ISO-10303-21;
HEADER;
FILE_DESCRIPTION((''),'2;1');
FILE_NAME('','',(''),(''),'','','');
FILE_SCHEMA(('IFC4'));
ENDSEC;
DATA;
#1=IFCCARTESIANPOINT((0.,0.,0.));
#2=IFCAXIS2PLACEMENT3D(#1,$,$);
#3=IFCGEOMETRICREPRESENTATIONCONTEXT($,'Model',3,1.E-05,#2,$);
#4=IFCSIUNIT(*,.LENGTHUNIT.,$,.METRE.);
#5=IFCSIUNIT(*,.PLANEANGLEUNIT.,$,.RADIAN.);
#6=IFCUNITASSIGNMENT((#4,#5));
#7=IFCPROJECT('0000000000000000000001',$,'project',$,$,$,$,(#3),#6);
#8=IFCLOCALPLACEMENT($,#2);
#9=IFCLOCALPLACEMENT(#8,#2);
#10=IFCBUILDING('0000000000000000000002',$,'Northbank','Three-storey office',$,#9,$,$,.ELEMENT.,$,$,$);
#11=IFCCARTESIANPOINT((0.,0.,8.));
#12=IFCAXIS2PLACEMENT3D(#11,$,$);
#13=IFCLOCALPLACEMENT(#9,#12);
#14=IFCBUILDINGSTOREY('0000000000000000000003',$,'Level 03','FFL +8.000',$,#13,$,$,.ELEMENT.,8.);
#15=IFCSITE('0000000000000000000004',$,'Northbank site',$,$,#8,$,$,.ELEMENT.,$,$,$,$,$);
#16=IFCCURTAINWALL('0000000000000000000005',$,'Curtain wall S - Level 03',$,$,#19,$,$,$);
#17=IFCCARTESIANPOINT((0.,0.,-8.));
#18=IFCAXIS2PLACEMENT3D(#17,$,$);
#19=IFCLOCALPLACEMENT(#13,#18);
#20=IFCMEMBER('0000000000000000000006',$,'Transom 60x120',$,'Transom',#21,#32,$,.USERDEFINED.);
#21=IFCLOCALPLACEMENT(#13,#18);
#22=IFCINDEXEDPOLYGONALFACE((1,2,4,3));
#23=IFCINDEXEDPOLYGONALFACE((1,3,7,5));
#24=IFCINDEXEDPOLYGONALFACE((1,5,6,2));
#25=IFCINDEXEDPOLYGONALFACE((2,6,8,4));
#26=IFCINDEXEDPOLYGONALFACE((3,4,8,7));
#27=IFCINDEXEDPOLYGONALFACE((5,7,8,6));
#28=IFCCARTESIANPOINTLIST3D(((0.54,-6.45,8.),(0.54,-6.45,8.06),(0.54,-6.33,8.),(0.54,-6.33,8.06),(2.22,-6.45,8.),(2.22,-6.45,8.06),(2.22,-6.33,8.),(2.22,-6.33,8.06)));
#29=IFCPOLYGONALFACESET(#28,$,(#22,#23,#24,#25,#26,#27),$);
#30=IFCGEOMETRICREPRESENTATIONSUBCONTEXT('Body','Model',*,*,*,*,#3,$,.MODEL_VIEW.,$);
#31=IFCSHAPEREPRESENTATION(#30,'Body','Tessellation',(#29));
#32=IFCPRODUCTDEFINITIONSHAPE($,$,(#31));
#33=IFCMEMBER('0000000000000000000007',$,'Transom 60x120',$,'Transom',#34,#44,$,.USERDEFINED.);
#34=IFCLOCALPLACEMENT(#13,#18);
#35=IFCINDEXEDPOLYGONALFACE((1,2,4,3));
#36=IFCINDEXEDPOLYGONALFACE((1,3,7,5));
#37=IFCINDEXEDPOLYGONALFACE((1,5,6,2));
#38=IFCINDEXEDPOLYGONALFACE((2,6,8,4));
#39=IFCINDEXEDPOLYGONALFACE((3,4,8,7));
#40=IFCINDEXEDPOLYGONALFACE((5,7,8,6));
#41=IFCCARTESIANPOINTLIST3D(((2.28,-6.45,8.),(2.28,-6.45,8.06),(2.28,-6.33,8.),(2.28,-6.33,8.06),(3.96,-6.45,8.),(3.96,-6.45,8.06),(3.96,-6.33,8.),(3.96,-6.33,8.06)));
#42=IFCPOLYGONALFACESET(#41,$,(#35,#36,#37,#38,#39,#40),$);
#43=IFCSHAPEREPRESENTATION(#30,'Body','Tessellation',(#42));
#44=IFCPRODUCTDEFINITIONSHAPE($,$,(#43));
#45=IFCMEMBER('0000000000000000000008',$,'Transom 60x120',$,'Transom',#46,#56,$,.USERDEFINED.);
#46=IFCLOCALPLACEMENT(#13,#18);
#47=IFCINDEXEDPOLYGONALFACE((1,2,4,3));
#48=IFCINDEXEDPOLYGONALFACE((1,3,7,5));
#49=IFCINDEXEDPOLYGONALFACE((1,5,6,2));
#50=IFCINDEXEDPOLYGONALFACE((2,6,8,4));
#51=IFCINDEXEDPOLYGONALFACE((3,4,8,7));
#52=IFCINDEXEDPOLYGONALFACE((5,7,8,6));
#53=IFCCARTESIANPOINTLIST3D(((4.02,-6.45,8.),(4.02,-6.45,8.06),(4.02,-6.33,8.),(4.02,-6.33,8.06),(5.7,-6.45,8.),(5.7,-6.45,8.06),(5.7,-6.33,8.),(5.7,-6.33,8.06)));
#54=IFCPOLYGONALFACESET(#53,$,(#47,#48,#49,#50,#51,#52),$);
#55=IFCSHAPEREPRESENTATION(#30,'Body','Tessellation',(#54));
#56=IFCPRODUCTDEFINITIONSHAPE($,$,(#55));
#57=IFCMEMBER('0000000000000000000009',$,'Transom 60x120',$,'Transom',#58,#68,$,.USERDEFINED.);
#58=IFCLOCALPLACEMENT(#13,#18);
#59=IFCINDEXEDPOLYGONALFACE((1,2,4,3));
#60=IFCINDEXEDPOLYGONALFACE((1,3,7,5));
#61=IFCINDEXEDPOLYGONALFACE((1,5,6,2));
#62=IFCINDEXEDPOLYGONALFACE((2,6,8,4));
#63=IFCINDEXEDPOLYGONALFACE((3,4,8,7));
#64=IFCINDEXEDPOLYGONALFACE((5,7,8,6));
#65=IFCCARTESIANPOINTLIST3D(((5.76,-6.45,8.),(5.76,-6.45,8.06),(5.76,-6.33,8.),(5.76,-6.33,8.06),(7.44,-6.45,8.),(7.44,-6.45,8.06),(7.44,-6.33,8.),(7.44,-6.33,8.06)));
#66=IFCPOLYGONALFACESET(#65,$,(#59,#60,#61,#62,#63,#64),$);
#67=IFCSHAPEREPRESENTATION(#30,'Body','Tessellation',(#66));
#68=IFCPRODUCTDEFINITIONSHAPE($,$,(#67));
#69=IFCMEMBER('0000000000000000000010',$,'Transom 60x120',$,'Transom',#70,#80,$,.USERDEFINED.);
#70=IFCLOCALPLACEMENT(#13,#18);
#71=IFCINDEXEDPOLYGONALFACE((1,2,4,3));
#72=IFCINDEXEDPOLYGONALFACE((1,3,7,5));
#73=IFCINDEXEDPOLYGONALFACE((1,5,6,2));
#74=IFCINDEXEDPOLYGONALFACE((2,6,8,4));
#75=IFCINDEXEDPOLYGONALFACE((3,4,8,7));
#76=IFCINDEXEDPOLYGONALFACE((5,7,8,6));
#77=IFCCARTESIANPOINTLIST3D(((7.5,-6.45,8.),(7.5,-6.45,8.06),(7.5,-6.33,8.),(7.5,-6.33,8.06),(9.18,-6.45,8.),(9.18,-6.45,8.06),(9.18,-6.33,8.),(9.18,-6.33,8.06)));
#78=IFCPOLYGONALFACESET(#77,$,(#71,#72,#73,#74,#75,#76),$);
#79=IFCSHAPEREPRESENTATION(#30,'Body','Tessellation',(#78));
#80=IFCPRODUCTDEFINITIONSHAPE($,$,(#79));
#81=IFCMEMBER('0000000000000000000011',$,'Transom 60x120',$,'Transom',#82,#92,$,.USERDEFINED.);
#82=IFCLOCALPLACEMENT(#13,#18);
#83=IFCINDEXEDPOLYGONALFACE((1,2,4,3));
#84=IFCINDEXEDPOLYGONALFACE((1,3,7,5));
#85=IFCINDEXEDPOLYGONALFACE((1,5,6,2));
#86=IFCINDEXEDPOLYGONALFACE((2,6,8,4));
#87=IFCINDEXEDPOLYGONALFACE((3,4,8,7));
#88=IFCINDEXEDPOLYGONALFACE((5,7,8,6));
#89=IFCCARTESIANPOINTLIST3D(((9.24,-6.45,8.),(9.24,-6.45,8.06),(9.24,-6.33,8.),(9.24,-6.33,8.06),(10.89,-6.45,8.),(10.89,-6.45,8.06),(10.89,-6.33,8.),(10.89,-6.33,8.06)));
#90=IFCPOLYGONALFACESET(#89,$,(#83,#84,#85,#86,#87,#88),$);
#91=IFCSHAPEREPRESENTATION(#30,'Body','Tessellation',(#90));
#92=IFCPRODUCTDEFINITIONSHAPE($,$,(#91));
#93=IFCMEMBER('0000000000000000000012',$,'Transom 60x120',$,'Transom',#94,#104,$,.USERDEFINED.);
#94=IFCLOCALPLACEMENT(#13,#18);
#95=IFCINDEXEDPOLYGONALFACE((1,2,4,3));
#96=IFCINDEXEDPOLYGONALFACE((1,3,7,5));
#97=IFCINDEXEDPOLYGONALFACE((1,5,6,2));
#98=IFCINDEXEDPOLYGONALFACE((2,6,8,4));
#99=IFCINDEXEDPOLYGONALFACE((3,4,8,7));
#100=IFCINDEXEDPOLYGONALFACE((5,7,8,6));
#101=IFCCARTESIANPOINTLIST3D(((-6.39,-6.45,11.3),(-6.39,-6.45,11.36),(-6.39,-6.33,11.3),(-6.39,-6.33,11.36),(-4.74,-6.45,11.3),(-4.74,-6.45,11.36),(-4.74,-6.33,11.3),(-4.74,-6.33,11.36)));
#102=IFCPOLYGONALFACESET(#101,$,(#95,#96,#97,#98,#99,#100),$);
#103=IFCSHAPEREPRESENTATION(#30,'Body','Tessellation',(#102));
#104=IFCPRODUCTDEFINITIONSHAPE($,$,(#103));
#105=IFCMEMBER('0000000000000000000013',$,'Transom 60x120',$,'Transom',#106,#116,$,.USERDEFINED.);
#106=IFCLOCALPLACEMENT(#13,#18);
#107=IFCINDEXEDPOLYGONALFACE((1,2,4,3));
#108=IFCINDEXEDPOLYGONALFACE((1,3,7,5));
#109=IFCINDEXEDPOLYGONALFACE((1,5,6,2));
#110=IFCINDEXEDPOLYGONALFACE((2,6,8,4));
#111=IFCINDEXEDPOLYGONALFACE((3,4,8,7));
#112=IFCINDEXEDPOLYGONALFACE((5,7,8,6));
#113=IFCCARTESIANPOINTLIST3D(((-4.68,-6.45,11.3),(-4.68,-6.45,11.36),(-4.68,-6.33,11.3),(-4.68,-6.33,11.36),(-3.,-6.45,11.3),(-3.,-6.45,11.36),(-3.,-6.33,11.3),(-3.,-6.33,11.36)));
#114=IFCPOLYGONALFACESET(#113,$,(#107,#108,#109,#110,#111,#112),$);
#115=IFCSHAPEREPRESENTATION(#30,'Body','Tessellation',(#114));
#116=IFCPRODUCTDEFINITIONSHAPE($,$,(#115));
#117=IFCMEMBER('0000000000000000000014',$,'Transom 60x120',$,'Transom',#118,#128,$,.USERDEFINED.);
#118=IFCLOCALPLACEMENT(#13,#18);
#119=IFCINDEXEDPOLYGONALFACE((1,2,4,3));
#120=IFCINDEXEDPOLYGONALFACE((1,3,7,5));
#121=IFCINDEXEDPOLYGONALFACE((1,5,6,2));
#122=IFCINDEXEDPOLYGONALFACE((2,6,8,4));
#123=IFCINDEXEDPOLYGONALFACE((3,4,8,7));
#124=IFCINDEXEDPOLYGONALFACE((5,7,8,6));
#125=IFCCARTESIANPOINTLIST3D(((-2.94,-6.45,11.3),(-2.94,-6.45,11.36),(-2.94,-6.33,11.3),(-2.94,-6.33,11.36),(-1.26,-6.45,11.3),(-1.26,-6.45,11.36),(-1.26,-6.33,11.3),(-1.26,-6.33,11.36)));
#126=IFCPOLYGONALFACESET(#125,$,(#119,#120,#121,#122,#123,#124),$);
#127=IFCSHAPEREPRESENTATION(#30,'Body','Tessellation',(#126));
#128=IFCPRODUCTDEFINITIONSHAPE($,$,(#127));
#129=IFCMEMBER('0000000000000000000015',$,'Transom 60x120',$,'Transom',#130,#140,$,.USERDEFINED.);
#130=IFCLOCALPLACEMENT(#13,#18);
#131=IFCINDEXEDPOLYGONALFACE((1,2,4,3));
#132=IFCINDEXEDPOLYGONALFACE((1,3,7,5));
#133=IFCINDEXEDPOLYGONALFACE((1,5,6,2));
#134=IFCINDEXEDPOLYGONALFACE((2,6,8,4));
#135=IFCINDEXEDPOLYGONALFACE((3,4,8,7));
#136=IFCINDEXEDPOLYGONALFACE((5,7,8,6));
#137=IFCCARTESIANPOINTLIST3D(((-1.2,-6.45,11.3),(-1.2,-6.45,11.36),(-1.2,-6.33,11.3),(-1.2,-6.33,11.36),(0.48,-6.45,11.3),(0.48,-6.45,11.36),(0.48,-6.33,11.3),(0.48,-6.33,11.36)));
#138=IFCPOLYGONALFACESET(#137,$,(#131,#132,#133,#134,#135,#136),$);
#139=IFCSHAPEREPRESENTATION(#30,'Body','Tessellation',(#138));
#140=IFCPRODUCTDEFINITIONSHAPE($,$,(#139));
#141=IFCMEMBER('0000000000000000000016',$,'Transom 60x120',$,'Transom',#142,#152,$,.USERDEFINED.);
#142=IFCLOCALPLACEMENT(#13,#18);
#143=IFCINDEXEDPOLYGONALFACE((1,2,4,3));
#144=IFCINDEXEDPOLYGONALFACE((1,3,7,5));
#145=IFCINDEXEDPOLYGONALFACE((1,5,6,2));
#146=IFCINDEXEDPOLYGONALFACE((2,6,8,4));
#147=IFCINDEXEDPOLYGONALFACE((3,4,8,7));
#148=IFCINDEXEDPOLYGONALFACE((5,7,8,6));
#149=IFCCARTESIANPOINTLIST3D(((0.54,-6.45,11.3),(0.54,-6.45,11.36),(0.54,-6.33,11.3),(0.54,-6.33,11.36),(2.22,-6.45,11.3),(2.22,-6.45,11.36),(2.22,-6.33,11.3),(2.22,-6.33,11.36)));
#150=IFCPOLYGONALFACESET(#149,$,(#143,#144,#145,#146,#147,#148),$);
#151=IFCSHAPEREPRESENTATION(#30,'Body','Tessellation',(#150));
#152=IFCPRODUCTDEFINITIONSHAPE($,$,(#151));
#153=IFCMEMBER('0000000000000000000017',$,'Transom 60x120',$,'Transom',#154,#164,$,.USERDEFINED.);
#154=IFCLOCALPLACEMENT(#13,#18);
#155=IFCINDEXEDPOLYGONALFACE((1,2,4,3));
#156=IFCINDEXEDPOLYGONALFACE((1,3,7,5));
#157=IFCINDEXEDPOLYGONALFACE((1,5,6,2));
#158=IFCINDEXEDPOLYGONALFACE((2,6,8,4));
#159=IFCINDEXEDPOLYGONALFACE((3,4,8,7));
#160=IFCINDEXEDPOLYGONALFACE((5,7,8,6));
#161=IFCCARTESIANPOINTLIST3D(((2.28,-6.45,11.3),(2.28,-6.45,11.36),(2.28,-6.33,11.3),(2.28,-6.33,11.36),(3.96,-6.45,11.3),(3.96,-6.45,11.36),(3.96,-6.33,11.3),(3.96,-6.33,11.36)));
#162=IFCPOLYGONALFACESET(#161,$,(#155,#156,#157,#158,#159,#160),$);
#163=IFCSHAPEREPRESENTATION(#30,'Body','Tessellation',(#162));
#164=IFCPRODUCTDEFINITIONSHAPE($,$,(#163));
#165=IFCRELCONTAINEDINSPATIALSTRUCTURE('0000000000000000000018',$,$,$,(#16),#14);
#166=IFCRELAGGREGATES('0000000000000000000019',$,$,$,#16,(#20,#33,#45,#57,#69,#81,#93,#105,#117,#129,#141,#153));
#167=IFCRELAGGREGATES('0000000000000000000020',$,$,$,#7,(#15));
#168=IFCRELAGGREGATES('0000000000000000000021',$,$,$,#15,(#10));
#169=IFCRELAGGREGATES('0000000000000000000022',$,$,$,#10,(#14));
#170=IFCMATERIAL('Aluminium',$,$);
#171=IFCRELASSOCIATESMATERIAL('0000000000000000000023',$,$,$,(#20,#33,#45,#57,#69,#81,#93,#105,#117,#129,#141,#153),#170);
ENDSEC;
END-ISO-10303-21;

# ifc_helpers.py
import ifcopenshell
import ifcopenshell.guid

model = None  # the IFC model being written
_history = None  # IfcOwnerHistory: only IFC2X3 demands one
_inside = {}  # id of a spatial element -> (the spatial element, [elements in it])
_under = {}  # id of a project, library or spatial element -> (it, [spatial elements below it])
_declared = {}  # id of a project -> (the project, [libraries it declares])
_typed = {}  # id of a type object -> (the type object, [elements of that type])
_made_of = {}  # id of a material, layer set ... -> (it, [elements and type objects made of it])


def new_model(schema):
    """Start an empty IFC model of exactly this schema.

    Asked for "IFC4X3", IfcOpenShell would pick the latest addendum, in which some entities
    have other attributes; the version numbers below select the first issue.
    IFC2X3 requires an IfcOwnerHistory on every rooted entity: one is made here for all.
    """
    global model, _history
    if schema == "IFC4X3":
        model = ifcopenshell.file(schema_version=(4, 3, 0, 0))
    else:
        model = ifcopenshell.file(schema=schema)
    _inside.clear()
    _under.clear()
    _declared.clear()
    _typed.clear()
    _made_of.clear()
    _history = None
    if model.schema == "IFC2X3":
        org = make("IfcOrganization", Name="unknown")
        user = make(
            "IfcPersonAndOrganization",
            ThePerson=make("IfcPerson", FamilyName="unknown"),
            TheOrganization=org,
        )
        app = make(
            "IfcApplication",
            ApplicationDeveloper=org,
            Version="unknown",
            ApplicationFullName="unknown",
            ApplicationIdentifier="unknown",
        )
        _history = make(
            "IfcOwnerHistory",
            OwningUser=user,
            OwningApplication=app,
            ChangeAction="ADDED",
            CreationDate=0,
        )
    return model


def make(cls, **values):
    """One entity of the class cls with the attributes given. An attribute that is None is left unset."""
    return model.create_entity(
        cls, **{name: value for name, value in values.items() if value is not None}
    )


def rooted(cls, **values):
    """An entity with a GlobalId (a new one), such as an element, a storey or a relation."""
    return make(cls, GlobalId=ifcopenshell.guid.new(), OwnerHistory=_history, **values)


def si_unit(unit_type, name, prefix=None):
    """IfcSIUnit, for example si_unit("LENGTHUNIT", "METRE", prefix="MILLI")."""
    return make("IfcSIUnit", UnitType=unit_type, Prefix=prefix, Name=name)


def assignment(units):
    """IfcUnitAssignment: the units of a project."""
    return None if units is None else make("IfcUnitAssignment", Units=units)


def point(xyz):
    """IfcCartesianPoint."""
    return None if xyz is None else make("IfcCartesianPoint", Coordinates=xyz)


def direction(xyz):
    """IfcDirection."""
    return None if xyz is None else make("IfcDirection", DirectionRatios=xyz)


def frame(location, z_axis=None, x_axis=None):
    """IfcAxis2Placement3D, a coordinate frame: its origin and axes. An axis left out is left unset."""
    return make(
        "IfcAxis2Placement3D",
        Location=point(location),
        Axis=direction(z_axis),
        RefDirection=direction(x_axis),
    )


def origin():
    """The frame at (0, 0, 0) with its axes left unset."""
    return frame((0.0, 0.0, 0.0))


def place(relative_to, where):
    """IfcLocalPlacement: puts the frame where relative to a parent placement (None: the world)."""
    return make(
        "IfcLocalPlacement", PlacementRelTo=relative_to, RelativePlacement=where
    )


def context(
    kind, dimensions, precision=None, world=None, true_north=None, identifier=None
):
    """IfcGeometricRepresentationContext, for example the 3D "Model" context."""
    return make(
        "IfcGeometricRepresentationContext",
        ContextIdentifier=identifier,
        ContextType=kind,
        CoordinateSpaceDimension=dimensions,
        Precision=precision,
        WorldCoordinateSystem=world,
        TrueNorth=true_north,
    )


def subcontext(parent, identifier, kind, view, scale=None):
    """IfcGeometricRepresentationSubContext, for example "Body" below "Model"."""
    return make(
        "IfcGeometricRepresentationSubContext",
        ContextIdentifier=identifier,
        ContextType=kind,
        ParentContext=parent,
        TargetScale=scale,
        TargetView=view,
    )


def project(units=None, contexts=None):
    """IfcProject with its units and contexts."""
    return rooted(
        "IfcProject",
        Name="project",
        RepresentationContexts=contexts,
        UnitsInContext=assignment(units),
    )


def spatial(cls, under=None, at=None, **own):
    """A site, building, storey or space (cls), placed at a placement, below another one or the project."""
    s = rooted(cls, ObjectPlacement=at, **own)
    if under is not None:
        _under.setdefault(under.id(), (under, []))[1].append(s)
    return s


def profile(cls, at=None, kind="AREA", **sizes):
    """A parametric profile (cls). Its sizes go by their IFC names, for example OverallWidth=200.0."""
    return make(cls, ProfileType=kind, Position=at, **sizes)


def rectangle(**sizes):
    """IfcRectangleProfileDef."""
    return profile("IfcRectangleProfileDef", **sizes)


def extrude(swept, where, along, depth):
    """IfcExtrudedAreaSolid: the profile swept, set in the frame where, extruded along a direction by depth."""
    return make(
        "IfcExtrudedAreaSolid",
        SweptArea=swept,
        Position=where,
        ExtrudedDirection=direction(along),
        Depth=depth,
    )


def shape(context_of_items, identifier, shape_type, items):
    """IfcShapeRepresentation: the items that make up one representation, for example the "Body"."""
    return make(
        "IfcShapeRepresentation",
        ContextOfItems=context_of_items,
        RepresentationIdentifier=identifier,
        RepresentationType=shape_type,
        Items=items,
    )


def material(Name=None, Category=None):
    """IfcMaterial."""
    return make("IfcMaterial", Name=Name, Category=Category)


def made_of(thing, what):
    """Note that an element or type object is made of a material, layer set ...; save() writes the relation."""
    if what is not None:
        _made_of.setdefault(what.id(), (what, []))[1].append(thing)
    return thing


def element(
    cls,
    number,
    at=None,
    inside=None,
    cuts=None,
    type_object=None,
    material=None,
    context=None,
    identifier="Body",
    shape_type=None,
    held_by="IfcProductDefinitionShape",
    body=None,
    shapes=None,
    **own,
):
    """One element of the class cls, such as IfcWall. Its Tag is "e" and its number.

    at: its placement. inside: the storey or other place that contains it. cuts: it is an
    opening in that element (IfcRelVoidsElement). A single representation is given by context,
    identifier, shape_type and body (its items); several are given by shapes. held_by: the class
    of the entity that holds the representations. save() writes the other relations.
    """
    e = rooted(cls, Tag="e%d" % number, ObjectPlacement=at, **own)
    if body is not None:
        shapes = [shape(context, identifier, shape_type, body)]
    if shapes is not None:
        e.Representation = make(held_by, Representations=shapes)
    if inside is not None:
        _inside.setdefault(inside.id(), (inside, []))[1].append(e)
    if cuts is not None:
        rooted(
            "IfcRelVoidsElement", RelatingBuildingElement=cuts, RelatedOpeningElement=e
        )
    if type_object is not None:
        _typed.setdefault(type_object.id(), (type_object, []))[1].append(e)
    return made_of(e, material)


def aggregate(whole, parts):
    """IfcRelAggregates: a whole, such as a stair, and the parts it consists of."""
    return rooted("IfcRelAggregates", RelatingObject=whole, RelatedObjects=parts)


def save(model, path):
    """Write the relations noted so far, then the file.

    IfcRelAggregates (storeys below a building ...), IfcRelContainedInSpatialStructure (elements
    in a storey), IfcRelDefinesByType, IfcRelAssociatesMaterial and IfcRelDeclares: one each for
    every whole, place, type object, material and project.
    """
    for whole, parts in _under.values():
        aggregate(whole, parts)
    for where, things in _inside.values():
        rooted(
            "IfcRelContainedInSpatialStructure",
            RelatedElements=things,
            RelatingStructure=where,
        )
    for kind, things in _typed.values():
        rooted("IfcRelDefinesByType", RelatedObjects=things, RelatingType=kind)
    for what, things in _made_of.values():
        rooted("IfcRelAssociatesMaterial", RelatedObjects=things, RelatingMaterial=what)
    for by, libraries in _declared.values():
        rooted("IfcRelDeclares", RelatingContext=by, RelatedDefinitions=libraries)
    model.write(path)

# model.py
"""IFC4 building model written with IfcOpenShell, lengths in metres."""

from ifc_helpers import new_model, si_unit, frame, origin, place, context, subcontext, project, spatial, rectangle, extrude, material, element, aggregate, save


model = new_model("IFC4")

# Units and contexts
model_context = context("Model", 3, precision=1e-05, world=origin())
body_context = subcontext(model_context, "Body", "Model", "MODEL_VIEW")
ifc_project = project(units=[si_unit("LENGTHUNIT", "METRE"), si_unit("PLANEANGLEUNIT", "RADIAN")], contexts=[model_context])

# Site, building, storey
site_placement = place(None, origin())
site = spatial("IfcSite", under=ifc_project, at=site_placement, Name="Northbank site", CompositionType="ELEMENT")
building_placement = place(site_placement, origin())
building = spatial("IfcBuilding", under=site, at=building_placement, Name="Northbank", Description="Three-storey office", CompositionType="ELEMENT")
storey_placement = place(building_placement, frame((0.0, 0.0, 8.0)))
storey = spatial("IfcBuildingStorey", under=building, at=storey_placement, Name="Level 03", Description="FFL +8.000", CompositionType="ELEMENT", Elevation=8.0)

# Curtain wall, members
curtain_wall_placement = place(storey_placement, frame((0.0, 0.0, -8.0)))
curtain_wall = element("IfcCurtainWall", 1, at=curtain_wall_placement, inside=storey, Name="Curtain wall S - Level 03")
ifc_material = material(Name="Aluminium")
member_1_placement = place(storey_placement, frame((0.0, 0.0, -8.0)))
member_1 = element("IfcMember", 2, at=member_1_placement, material=ifc_material, Name="Transom 60x120", ObjectType="Transom", PredefinedType="USERDEFINED", context=body_context, shape_type="SweptSolid", body=[
    extrude(rectangle(XDim=1.68, YDim=0.12), frame((1.38, -6.39, 8.0)), (0.0, 0.0, 1.0), 0.06),
])
member_2_placement = place(storey_placement, frame((0.0, 0.0, -8.0)))
member_2 = element("IfcMember", 3, at=member_2_placement, material=ifc_material, Name="Transom 60x120", ObjectType="Transom", PredefinedType="USERDEFINED", context=body_context, shape_type="SweptSolid", body=[
    extrude(rectangle(XDim=1.68, YDim=0.12), frame((3.12, -6.39, 8.0)), (0.0, 0.0, 1.0), 0.06),
])
member_3_placement = place(storey_placement, frame((0.0, 0.0, -8.0)))
member_3 = element("IfcMember", 4, at=member_3_placement, material=ifc_material, Name="Transom 60x120", ObjectType="Transom", PredefinedType="USERDEFINED", context=body_context, shape_type="SweptSolid", body=[
    extrude(rectangle(XDim=1.68, YDim=0.12), frame((4.86, -6.39, 8.0)), (0.0, 0.0, 1.0), 0.06),
])
member_4_placement = place(storey_placement, frame((0.0, 0.0, -8.0)))
member_4 = element("IfcMember", 5, at=member_4_placement, material=ifc_material, Name="Transom 60x120", ObjectType="Transom", PredefinedType="USERDEFINED", context=body_context, shape_type="SweptSolid", body=[
    extrude(rectangle(XDim=1.68, YDim=0.12), frame((6.6, -6.39, 8.0)), (0.0, 0.0, 1.0), 0.06),
])
member_5_placement = place(storey_placement, frame((0.0, 0.0, -8.0)))
member_5 = element("IfcMember", 6, at=member_5_placement, material=ifc_material, Name="Transom 60x120", ObjectType="Transom", PredefinedType="USERDEFINED", context=body_context, shape_type="SweptSolid", body=[
    extrude(rectangle(XDim=1.68, YDim=0.12), frame((8.34, -6.39, 8.0)), (0.0, 0.0, 1.0), 0.06),
])
member_6_placement = place(storey_placement, frame((0.0, 0.0, -8.0)))
member_6 = element("IfcMember", 7, at=member_6_placement, material=ifc_material, Name="Transom 60x120", ObjectType="Transom", PredefinedType="USERDEFINED", context=body_context, shape_type="SweptSolid", body=[
    extrude(rectangle(XDim=1.65, YDim=0.12), frame((10.065, -6.39, 8.0)), (0.0, 0.0, 1.0), 0.06),
])
member_7_placement = place(storey_placement, frame((0.0, 0.0, -8.0)))
member_7 = element("IfcMember", 8, at=member_7_placement, material=ifc_material, Name="Transom 60x120", ObjectType="Transom", PredefinedType="USERDEFINED", context=body_context, shape_type="SweptSolid", body=[
    extrude(rectangle(XDim=1.65, YDim=0.12), frame((-5.565, -6.39, 11.3)), (0.0, 0.0, 1.0), 0.06),
])
member_8_placement = place(storey_placement, frame((0.0, 0.0, -8.0)))
member_8 = element("IfcMember", 9, at=member_8_placement, material=ifc_material, Name="Transom 60x120", ObjectType="Transom", PredefinedType="USERDEFINED", context=body_context, shape_type="SweptSolid", body=[
    extrude(rectangle(XDim=1.68, YDim=0.12), frame((-3.84, -6.39, 11.3)), (0.0, 0.0, 1.0), 0.06),
])
member_9_placement = place(storey_placement, frame((0.0, 0.0, -8.0)))
member_9 = element("IfcMember", 10, at=member_9_placement, material=ifc_material, Name="Transom 60x120", ObjectType="Transom", PredefinedType="USERDEFINED", context=body_context, shape_type="SweptSolid", body=[
    extrude(rectangle(XDim=1.68, YDim=0.12), frame((-2.1, -6.39, 11.3)), (0.0, 0.0, 1.0), 0.06),
])
member_10_placement = place(storey_placement, frame((0.0, 0.0, -8.0)))
member_10 = element("IfcMember", 11, at=member_10_placement, material=ifc_material, Name="Transom 60x120", ObjectType="Transom", PredefinedType="USERDEFINED", context=body_context, shape_type="SweptSolid", body=[
    extrude(rectangle(XDim=1.68, YDim=0.12), frame((-0.36, -6.39, 11.3)), (0.0, 0.0, 1.0), 0.06),
])
member_11_placement = place(storey_placement, frame((0.0, 0.0, -8.0)))
member_11 = element("IfcMember", 12, at=member_11_placement, material=ifc_material, Name="Transom 60x120", ObjectType="Transom", PredefinedType="USERDEFINED", context=body_context, shape_type="SweptSolid", body=[
    extrude(rectangle(XDim=1.68, YDim=0.12), frame((1.38, -6.39, 11.3)), (0.0, 0.0, 1.0), 0.06),
])
member_12_placement = place(storey_placement, frame((0.0, 0.0, -8.0)))
member_12 = element("IfcMember", 13, at=member_12_placement, material=ifc_material, Name="Transom 60x120", ObjectType="Transom", PredefinedType="USERDEFINED", context=body_context, shape_type="SweptSolid", body=[
    extrude(rectangle(XDim=1.68, YDim=0.12), frame((3.12, -6.39, 11.3)), (0.0, 0.0, 1.0), 0.06),
])
aggregate(curtain_wall, [member_1, member_2, member_3, member_4, member_5, member_6, member_7, member_8, member_9, member_10, member_11, member_12])

save(model, "model.ifc")
